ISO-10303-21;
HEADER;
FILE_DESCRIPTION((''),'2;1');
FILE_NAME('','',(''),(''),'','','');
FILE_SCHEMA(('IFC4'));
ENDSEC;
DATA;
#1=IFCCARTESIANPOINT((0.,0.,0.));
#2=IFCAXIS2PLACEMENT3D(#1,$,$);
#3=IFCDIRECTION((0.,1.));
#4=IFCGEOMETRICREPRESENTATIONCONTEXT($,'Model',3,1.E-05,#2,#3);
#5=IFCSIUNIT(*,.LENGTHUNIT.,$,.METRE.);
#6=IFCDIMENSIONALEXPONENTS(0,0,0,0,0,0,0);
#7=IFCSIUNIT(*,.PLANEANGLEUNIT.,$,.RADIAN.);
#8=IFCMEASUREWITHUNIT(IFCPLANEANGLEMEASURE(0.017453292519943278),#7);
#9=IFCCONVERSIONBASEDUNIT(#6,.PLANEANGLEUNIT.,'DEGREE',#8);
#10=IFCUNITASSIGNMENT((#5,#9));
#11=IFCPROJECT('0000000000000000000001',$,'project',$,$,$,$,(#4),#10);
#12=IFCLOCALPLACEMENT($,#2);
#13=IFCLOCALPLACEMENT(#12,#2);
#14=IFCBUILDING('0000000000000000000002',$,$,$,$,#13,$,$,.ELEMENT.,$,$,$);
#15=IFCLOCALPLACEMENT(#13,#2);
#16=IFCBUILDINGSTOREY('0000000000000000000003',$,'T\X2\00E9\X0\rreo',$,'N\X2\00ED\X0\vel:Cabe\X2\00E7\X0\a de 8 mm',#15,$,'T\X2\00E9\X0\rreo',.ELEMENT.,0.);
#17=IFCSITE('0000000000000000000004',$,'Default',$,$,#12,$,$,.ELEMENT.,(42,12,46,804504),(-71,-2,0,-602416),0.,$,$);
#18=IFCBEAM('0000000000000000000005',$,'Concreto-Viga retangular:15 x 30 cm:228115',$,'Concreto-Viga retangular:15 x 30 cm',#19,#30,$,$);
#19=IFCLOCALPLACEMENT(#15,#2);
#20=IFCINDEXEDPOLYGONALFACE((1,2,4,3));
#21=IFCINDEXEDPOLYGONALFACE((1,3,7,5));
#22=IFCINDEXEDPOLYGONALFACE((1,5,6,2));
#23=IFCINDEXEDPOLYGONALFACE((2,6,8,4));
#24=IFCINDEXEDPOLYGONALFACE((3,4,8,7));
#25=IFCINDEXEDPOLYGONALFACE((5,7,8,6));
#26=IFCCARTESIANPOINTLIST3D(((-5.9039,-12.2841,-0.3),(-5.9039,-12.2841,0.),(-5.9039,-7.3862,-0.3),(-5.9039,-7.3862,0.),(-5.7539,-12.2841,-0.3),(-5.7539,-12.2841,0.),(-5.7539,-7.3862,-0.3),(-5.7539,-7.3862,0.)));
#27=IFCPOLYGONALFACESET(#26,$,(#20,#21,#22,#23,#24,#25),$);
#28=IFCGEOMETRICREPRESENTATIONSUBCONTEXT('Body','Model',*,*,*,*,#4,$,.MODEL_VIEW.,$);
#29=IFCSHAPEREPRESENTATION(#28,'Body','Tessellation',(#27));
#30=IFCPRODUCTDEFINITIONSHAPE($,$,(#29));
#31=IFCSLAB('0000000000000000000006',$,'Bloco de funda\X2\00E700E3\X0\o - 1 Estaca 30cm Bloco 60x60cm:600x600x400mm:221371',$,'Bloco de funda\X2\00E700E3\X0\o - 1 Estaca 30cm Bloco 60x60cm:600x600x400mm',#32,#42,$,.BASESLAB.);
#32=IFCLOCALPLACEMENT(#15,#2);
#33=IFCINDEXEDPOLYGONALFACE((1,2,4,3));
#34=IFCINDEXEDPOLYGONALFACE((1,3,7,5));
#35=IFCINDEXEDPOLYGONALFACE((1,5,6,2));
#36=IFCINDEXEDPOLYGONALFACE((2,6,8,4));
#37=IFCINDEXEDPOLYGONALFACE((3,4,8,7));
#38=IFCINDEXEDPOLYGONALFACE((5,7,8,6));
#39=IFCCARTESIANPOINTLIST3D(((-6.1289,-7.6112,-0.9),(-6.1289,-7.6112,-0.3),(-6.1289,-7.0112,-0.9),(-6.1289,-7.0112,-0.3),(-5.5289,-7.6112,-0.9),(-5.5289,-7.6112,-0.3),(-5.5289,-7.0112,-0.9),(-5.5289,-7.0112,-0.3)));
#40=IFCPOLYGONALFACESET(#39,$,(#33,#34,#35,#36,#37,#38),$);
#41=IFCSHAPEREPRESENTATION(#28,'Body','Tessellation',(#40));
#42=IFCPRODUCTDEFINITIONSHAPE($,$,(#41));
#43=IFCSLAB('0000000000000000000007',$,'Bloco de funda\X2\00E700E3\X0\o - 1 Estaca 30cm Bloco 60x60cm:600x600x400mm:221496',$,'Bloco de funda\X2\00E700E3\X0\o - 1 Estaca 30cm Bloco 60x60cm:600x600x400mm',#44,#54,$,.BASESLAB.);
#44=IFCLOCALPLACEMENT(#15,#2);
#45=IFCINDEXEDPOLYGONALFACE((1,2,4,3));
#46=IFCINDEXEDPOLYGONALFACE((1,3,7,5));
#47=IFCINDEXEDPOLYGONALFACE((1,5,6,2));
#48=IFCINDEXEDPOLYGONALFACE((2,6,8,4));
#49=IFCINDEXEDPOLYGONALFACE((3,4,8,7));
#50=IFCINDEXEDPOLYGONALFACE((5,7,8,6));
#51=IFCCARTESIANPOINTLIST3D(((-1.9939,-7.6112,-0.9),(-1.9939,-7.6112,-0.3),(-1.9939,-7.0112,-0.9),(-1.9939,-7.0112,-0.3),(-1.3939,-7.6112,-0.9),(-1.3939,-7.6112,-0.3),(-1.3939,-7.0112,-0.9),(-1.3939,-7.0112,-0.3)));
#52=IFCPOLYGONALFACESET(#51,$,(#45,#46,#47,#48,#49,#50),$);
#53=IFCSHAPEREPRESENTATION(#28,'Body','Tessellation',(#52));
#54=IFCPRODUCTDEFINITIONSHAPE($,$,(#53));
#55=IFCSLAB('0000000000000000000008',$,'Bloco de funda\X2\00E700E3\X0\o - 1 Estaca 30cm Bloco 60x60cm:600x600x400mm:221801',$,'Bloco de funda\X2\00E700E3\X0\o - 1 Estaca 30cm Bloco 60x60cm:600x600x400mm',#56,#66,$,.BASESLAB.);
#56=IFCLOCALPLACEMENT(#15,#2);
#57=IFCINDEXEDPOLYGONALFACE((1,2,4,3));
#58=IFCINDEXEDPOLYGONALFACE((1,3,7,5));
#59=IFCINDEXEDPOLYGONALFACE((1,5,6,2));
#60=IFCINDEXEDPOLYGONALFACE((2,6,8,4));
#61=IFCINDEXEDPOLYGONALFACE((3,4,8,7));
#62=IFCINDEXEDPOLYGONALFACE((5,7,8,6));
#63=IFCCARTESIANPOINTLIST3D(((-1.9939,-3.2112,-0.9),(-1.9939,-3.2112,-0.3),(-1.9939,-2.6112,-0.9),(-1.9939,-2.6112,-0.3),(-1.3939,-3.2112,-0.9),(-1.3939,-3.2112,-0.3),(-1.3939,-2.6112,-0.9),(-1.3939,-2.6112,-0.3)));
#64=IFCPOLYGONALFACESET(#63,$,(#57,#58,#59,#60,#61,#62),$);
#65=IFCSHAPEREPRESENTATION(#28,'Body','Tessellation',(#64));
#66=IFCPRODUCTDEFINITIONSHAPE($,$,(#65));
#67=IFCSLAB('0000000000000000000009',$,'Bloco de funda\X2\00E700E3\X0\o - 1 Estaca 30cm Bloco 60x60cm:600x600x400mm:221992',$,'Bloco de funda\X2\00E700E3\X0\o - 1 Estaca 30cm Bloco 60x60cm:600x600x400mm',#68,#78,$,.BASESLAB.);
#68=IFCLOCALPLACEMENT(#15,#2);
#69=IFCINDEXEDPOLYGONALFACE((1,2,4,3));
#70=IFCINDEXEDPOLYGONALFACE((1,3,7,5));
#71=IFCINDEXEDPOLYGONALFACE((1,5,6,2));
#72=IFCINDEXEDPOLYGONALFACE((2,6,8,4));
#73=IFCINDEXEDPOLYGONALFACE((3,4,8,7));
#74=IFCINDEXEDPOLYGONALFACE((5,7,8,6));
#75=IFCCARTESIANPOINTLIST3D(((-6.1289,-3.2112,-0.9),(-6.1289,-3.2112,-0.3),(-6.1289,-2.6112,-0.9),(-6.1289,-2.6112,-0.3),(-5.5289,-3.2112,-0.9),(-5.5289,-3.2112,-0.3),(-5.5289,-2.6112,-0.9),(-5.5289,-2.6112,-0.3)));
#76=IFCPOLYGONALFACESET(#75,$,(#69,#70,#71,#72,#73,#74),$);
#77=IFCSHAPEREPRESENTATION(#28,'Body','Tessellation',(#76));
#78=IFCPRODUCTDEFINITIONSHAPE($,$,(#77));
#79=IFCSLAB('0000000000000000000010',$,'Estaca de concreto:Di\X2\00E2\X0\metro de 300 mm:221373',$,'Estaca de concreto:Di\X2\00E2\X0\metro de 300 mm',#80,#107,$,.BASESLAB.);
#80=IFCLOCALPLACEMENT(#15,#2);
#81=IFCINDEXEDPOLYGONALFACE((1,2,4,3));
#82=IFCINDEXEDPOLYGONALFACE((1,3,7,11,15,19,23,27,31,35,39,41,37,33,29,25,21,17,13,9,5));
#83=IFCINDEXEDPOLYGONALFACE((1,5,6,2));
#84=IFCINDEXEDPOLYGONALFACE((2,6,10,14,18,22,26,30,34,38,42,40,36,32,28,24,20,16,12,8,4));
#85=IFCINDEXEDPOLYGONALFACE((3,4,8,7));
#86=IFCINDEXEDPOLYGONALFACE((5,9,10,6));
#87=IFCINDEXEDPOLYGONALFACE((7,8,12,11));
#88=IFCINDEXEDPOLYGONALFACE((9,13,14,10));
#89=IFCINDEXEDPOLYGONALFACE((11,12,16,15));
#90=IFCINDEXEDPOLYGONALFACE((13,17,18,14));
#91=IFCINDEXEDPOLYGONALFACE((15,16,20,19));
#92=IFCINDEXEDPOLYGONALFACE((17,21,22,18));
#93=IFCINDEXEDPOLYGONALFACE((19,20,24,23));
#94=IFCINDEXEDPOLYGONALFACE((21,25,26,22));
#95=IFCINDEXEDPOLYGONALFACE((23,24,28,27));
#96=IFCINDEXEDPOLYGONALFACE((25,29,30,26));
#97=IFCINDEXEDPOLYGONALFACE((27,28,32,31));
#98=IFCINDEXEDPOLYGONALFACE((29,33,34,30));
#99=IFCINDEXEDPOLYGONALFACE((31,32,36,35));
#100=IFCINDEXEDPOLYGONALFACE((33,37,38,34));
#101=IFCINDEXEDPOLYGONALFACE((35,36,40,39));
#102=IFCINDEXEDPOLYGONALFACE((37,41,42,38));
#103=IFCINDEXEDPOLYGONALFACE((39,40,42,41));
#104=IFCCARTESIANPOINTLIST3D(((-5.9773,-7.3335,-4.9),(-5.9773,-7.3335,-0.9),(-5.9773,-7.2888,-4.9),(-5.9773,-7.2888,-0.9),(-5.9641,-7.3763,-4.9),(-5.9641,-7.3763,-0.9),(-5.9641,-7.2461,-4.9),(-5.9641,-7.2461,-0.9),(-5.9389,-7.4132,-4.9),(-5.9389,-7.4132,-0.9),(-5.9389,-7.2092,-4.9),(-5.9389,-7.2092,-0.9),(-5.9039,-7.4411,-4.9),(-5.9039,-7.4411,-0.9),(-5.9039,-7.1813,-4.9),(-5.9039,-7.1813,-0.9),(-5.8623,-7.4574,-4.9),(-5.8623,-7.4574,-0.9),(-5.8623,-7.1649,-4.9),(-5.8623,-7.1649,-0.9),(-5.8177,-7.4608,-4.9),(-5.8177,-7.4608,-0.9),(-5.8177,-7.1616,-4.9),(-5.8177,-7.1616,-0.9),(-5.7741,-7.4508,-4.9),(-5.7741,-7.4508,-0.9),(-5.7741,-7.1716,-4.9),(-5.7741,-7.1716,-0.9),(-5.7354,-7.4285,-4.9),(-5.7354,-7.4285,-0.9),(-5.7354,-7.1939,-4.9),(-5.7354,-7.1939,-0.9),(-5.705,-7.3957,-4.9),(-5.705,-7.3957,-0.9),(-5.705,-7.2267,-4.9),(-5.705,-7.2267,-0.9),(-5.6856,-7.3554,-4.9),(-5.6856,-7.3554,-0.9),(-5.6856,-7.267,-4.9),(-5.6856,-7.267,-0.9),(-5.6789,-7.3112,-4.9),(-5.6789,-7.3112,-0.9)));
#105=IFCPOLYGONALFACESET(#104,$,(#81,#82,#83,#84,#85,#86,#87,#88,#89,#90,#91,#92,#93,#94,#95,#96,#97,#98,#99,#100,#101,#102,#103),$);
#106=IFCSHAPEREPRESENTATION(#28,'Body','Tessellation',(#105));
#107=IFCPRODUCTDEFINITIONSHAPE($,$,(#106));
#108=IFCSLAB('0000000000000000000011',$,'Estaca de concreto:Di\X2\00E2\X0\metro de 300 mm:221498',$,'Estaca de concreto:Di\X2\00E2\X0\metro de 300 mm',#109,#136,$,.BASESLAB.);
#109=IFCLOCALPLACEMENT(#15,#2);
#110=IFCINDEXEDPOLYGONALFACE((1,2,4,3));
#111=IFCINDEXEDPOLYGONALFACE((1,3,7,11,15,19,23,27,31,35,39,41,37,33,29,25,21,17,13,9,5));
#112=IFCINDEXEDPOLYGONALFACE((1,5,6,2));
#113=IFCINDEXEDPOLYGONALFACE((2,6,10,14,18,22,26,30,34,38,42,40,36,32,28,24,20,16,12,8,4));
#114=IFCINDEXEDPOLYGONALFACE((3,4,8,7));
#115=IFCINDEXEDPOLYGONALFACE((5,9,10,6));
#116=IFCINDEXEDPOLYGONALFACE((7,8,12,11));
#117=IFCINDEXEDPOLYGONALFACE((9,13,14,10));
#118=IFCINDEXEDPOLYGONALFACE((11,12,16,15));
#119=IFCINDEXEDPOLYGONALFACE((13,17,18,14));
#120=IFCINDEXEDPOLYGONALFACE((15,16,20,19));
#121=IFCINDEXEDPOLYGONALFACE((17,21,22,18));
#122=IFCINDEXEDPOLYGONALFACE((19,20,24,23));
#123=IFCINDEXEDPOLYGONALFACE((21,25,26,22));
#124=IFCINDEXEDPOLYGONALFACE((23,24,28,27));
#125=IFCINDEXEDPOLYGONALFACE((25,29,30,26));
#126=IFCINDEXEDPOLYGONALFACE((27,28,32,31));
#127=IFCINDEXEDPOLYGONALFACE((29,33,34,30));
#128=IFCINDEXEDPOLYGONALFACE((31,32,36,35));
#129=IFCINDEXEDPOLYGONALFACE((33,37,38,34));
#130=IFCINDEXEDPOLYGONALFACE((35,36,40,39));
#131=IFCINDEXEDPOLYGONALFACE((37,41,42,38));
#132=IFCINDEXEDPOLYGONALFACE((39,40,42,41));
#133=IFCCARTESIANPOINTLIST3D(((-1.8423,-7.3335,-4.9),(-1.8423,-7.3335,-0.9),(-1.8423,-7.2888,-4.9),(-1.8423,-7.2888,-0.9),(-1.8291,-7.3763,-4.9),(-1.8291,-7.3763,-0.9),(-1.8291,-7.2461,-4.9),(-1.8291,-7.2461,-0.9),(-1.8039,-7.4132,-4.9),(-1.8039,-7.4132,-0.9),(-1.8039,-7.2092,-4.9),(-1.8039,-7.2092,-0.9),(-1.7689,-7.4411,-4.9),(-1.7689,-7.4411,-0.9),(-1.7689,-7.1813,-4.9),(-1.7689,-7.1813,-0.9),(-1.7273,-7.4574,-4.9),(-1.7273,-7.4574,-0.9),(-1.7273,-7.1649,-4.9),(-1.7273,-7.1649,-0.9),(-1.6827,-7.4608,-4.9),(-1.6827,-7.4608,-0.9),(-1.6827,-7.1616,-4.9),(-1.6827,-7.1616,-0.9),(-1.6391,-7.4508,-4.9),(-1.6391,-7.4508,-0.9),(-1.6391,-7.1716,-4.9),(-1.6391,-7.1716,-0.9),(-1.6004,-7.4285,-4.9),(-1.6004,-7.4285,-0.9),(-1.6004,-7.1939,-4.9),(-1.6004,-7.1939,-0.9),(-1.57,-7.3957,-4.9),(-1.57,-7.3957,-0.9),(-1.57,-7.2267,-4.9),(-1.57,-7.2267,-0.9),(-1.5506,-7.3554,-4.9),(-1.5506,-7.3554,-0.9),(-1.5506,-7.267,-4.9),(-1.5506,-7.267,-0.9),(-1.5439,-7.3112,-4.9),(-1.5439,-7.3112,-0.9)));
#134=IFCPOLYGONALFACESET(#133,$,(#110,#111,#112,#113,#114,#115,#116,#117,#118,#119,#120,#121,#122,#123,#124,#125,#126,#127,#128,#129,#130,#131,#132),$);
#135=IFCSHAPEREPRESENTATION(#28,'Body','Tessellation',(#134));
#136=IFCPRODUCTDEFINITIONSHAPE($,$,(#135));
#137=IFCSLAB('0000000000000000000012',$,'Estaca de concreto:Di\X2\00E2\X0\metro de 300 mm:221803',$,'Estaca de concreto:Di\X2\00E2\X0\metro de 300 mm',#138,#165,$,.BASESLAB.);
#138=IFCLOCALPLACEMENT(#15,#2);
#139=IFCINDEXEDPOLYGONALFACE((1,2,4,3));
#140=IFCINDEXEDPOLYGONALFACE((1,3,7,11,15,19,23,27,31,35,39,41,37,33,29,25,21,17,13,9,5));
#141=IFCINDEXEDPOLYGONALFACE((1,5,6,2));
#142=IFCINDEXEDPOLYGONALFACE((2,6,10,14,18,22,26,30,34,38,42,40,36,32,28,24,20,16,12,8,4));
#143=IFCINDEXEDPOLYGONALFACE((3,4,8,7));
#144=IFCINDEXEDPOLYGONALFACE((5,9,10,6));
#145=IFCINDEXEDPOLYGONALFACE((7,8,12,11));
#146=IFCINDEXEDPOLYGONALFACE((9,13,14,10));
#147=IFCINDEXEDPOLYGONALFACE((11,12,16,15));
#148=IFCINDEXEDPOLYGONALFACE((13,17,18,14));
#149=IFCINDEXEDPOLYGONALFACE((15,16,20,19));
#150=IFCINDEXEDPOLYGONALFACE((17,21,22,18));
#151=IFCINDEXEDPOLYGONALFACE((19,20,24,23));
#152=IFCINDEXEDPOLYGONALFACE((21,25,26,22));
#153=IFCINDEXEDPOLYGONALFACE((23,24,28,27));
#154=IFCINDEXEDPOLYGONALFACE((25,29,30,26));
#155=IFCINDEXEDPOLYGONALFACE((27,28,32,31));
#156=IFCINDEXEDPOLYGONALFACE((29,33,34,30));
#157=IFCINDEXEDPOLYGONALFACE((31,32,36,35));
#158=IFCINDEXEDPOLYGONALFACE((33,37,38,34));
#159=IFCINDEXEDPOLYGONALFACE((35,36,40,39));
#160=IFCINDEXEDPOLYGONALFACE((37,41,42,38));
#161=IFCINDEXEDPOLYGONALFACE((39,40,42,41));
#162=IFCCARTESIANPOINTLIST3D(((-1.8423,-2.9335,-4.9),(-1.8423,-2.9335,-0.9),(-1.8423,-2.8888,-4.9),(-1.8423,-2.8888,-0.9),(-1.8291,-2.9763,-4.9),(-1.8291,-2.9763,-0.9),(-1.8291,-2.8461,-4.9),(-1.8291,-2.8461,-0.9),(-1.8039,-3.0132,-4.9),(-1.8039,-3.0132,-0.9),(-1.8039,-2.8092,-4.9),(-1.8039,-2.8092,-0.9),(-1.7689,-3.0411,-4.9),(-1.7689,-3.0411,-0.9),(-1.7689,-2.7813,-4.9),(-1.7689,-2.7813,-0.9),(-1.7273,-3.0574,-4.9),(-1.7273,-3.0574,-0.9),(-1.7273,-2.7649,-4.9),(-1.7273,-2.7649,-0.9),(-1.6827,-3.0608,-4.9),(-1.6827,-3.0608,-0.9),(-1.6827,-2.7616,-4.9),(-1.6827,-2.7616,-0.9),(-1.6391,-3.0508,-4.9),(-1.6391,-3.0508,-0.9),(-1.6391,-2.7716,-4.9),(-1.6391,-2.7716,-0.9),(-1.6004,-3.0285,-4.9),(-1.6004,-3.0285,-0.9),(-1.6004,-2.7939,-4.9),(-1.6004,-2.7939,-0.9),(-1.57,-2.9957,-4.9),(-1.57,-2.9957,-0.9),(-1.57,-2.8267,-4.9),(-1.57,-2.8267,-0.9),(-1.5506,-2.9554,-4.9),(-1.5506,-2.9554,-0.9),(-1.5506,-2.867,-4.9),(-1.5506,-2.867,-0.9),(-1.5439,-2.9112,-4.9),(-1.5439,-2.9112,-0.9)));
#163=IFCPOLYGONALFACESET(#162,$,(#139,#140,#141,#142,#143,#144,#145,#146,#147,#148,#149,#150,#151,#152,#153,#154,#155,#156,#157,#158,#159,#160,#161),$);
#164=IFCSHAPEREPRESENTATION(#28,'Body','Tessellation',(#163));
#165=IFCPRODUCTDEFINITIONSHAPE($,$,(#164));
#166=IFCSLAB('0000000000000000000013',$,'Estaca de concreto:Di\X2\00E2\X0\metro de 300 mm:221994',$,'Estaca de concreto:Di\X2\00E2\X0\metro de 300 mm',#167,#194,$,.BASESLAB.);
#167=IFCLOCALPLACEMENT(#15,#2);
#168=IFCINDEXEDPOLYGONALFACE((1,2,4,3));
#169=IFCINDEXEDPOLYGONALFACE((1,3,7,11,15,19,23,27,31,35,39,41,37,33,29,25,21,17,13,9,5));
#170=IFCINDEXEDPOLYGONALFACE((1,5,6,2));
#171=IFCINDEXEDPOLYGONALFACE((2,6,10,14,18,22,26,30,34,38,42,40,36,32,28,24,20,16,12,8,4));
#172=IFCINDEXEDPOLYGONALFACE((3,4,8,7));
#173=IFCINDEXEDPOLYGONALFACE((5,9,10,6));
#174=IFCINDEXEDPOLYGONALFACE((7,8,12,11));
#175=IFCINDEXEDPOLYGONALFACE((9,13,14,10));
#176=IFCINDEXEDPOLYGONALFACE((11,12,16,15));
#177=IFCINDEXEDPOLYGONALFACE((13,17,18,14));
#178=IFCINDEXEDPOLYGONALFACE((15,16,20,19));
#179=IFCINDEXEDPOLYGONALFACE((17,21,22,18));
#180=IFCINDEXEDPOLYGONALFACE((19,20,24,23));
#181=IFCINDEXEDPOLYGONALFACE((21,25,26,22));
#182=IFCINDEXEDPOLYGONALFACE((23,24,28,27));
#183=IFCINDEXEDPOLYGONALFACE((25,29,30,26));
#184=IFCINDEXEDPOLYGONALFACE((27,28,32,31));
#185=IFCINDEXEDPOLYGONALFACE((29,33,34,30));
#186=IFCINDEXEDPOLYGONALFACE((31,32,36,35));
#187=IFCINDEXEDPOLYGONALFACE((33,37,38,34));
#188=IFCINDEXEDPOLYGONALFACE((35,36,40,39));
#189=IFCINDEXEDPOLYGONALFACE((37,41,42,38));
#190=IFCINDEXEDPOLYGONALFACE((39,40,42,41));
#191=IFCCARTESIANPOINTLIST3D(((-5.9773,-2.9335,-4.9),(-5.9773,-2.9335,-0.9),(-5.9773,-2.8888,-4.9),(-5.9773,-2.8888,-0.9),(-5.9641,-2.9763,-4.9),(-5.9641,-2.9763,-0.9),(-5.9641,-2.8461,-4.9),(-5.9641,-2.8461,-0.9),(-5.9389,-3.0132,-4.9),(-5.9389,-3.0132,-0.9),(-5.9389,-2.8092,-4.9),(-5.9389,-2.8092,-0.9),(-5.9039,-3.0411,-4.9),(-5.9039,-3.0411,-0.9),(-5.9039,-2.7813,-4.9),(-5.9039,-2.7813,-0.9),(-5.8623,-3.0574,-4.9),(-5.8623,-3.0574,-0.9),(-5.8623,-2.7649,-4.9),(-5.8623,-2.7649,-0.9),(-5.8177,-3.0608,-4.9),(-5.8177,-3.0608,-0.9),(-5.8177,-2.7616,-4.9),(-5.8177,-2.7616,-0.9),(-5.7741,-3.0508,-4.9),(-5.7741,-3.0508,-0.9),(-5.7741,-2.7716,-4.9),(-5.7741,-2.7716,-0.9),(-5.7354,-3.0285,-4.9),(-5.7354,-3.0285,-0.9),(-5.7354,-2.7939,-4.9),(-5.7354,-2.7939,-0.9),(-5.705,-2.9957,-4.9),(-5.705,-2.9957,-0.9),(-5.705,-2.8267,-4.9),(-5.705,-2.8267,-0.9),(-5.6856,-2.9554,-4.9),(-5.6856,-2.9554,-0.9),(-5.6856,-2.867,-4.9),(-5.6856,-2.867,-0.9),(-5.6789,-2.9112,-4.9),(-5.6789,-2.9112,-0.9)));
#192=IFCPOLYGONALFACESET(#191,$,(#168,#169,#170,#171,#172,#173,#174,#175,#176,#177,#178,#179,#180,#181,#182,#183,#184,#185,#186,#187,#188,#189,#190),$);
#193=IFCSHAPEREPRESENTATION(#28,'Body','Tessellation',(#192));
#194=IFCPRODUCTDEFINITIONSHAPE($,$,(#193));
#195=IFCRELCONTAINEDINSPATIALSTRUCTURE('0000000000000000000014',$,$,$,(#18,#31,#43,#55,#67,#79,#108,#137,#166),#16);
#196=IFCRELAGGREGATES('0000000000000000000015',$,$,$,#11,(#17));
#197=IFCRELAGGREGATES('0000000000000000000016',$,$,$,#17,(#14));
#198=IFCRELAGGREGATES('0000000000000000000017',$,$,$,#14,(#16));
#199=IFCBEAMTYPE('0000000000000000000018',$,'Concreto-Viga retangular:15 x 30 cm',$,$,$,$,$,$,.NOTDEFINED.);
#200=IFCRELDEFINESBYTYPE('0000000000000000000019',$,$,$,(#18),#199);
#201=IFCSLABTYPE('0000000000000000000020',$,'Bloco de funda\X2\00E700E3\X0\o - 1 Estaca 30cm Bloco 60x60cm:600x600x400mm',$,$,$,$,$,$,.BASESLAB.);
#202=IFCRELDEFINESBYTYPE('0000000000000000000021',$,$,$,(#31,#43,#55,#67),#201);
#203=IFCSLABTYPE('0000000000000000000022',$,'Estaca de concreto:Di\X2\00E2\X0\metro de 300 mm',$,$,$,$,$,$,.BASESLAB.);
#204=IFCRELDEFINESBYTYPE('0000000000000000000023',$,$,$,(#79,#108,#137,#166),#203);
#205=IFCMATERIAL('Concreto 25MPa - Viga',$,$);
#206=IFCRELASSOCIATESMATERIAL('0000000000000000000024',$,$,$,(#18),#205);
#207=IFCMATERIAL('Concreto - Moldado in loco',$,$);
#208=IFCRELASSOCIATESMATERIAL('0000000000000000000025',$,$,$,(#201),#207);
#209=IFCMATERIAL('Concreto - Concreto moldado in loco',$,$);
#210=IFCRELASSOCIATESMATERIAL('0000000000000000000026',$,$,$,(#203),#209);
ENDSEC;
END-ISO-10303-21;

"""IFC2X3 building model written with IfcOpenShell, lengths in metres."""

from ifc_helpers import new_model, entity, si_unit, converted_unit, direction, frame, frame_2d, origin, origin_2d_with_axis, place, context, subcontext, project, spatial, rectangle, circle, extrude, material, type_object, element, save


model = new_model("IFC2X3")

# Units and contexts
model_context = context("Model", 3, precision=1e-05, world=origin(), true_north=direction((0.0, 1.0)))
body_context = subcontext(model_context, "Body", "Model", "MODEL_VIEW")
ifc_project = project(units=[si_unit("LENGTHUNIT", "METRE"), converted_unit("PLANEANGLEUNIT", "DEGREE", entity("IfcPlaneAngleMeasure", 0.017453292519943278), si_unit("PLANEANGLEUNIT", "RADIAN"), dimensions=[0, 0, 0, 0, 0, 0, 0])], contexts=[model_context])

# Site, building, storey
site_placement = place(None, origin())
site = spatial("IfcSite", under=ifc_project, at=site_placement, Name="Default", CompositionType="ELEMENT", RefLatitude=(42, 12, 46, 804504), RefLongitude=(-71, -2, 0, -602416), RefElevation=0.0)
building_placement = place(site_placement, origin())
building = spatial("IfcBuilding", under=site, at=building_placement, CompositionType="ELEMENT")
storey_placement = place(building_placement, origin())
storey = spatial("IfcBuildingStorey", under=building, at=storey_placement, Name="Térreo", ObjectType="Nível:Cabeça de 8 mm", LongName="Térreo", CompositionType="ELEMENT", Elevation=0.0)

# Beam
ifc_material_1 = material(Name="Concreto 25MPa - Viga")
beam_type = type_object("IfcBeamType", Name="Concreto-Viga retangular:15 x 30 cm", PredefinedType="NOTDEFINED")
beam_1_placement = place(storey_placement, frame((-5.8289, -7.3112, 0.0), z_axis=(0.0, 0.0, 1.0), x_axis=(0.0, -1.0, 0.0)))
element("IfcBeam", 1, at=beam_1_placement, inside=storey, type_object=beam_type, material=ifc_material_1, Name="Concreto-Viga retangular:15 x 30 cm:228115", ObjectType="Concreto-Viga retangular:15 x 30 cm", context=body_context, shape_type="SweptSolid", body=[
    extrude(rectangle(XDim=0.3, YDim=0.15, at=frame_2d((0.0, 0.0), x_axis=(1.0, 0.0))), frame((0.075, 0.0, -0.15), z_axis=(1.0, 0.0, 0.0), x_axis=(0.0, 0.0, -1.0)), (0.0, 0.0, 1.0), 4.8979),
])

# Slabs
ifc_material_2 = material(Name="Concreto - Moldado in loco")
slab_type_1 = type_object("IfcSlabType", Name="Bloco de fundação - 1 Estaca 30cm Bloco 60x60cm:600x600x400mm", PredefinedType="BASESLAB", material=ifc_material_2)
slab_1_placement = place(storey_placement, origin())
element("IfcSlab", 2, at=slab_1_placement, inside=storey, type_object=slab_type_1, Name="Bloco de fundação - 1 Estaca 30cm Bloco 60x60cm:600x600x400mm:221371", ObjectType="Bloco de fundação - 1 Estaca 30cm Bloco 60x60cm:600x600x400mm", PredefinedType="BASESLAB", context=body_context, shape_type="SweptSolid", body=[
    extrude(rectangle(XDim=0.6, YDim=0.6, at=origin_2d_with_axis()), frame((-5.8289, -7.3112, -0.9), z_axis=(0.0, 0.0, 1.0), x_axis=(-1.0, 0.0, 0.0)), (0.0, 0.0, 1.0), 0.6),
])
slab_2_placement = place(storey_placement, origin())
element("IfcSlab", 3, at=slab_2_placement, inside=storey, type_object=slab_type_1, Name="Bloco de fundação - 1 Estaca 30cm Bloco 60x60cm:600x600x400mm:221496", ObjectType="Bloco de fundação - 1 Estaca 30cm Bloco 60x60cm:600x600x400mm", PredefinedType="BASESLAB", context=body_context, shape_type="SweptSolid", body=[
    extrude(rectangle(XDim=0.6, YDim=0.6, at=frame_2d((0.0, 0.0), x_axis=(1.0, 0.0))), frame((-1.6939, -7.3112, -0.9), z_axis=(0.0, 0.0, 1.0), x_axis=(-1.0, 0.0, 0.0)), (0.0, 0.0, 1.0), 0.6),
])
slab_3_placement = place(storey_placement, origin())
element("IfcSlab", 4, at=slab_3_placement, inside=storey, type_object=slab_type_1, Name="Bloco de fundação - 1 Estaca 30cm Bloco 60x60cm:600x600x400mm:221801", ObjectType="Bloco de fundação - 1 Estaca 30cm Bloco 60x60cm:600x600x400mm", PredefinedType="BASESLAB", context=body_context, shape_type="SweptSolid", body=[
    extrude(rectangle(XDim=0.6, YDim=0.6, at=frame_2d((0.0, 0.0), x_axis=(1.0, 0.0))), frame((-1.6939, -2.9112, -0.9), z_axis=(0.0, 0.0, 1.0), x_axis=(-1.0, 0.0, 0.0)), (0.0, 0.0, 1.0), 0.6),
])
slab_4_placement = place(storey_placement, origin())
element("IfcSlab", 5, at=slab_4_placement, inside=storey, type_object=slab_type_1, Name="Bloco de fundação - 1 Estaca 30cm Bloco 60x60cm:600x600x400mm:221992", ObjectType="Bloco de fundação - 1 Estaca 30cm Bloco 60x60cm:600x600x400mm", PredefinedType="BASESLAB", context=body_context, shape_type="SweptSolid", body=[
    extrude(rectangle(XDim=0.6, YDim=0.6, at=origin_2d_with_axis()), frame((-5.8289, -2.9112, -0.9), z_axis=(0.0, 0.0, 1.0), x_axis=(-1.0, 0.0, 0.0)), (0.0, 0.0, 1.0), 0.6),
])
ifc_material_3 = material(Name="Concreto - Concreto moldado in loco")
slab_type_2 = type_object("IfcSlabType", Name="Estaca de concreto:Diâmetro de 300 mm", PredefinedType="BASESLAB", material=ifc_material_3)
slab_5_placement = place(storey_placement, origin())
element("IfcSlab", 6, at=slab_5_placement, inside=storey, type_object=slab_type_2, Name="Estaca de concreto:Diâmetro de 300 mm:221373", ObjectType="Estaca de concreto:Diâmetro de 300 mm", PredefinedType="BASESLAB", context=body_context, shape_type="SweptSolid", body=[
    extrude(circle(Radius=0.15, at=origin_2d_with_axis()), frame((-5.8289, -7.3112, -4.9)), (0.0, 0.0, 1.0), 4.0),
])
slab_6_placement = place(storey_placement, origin())
element("IfcSlab", 7, at=slab_6_placement, inside=storey, type_object=slab_type_2, Name="Estaca de concreto:Diâmetro de 300 mm:221498", ObjectType="Estaca de concreto:Diâmetro de 300 mm", PredefinedType="BASESLAB", context=body_context, shape_type="SweptSolid", body=[
    extrude(circle(Radius=0.15, at=origin_2d_with_axis()), frame((-1.6939, -7.3112, -4.9)), (0.0, 0.0, 1.0), 4.0),
])
slab_7_placement = place(storey_placement, origin())
element("IfcSlab", 8, at=slab_7_placement, inside=storey, type_object=slab_type_2, Name="Estaca de concreto:Diâmetro de 300 mm:221803", ObjectType="Estaca de concreto:Diâmetro de 300 mm", PredefinedType="BASESLAB", context=body_context, shape_type="SweptSolid", body=[
    extrude(circle(Radius=0.15, at=frame_2d((0.0, 0.0), x_axis=(1.0, 0.0))), frame((-1.6939, -2.9112, -4.9)), (0.0, 0.0, 1.0), 4.0),
])
slab_8_placement = place(storey_placement, origin())
element("IfcSlab", 9, at=slab_8_placement, inside=storey, type_object=slab_type_2, Name="Estaca de concreto:Diâmetro de 300 mm:221994", ObjectType="Estaca de concreto:Diâmetro de 300 mm", PredefinedType="BASESLAB", context=body_context, shape_type="SweptSolid", body=[
    extrude(circle(Radius=0.15, at=frame_2d((0.0, 0.0), x_axis=(1.0, 0.0))), frame((-5.8289, -2.9112, -4.9)), (0.0, 0.0, 1.0), 4.0),
])

save(model, "model.ifc")
